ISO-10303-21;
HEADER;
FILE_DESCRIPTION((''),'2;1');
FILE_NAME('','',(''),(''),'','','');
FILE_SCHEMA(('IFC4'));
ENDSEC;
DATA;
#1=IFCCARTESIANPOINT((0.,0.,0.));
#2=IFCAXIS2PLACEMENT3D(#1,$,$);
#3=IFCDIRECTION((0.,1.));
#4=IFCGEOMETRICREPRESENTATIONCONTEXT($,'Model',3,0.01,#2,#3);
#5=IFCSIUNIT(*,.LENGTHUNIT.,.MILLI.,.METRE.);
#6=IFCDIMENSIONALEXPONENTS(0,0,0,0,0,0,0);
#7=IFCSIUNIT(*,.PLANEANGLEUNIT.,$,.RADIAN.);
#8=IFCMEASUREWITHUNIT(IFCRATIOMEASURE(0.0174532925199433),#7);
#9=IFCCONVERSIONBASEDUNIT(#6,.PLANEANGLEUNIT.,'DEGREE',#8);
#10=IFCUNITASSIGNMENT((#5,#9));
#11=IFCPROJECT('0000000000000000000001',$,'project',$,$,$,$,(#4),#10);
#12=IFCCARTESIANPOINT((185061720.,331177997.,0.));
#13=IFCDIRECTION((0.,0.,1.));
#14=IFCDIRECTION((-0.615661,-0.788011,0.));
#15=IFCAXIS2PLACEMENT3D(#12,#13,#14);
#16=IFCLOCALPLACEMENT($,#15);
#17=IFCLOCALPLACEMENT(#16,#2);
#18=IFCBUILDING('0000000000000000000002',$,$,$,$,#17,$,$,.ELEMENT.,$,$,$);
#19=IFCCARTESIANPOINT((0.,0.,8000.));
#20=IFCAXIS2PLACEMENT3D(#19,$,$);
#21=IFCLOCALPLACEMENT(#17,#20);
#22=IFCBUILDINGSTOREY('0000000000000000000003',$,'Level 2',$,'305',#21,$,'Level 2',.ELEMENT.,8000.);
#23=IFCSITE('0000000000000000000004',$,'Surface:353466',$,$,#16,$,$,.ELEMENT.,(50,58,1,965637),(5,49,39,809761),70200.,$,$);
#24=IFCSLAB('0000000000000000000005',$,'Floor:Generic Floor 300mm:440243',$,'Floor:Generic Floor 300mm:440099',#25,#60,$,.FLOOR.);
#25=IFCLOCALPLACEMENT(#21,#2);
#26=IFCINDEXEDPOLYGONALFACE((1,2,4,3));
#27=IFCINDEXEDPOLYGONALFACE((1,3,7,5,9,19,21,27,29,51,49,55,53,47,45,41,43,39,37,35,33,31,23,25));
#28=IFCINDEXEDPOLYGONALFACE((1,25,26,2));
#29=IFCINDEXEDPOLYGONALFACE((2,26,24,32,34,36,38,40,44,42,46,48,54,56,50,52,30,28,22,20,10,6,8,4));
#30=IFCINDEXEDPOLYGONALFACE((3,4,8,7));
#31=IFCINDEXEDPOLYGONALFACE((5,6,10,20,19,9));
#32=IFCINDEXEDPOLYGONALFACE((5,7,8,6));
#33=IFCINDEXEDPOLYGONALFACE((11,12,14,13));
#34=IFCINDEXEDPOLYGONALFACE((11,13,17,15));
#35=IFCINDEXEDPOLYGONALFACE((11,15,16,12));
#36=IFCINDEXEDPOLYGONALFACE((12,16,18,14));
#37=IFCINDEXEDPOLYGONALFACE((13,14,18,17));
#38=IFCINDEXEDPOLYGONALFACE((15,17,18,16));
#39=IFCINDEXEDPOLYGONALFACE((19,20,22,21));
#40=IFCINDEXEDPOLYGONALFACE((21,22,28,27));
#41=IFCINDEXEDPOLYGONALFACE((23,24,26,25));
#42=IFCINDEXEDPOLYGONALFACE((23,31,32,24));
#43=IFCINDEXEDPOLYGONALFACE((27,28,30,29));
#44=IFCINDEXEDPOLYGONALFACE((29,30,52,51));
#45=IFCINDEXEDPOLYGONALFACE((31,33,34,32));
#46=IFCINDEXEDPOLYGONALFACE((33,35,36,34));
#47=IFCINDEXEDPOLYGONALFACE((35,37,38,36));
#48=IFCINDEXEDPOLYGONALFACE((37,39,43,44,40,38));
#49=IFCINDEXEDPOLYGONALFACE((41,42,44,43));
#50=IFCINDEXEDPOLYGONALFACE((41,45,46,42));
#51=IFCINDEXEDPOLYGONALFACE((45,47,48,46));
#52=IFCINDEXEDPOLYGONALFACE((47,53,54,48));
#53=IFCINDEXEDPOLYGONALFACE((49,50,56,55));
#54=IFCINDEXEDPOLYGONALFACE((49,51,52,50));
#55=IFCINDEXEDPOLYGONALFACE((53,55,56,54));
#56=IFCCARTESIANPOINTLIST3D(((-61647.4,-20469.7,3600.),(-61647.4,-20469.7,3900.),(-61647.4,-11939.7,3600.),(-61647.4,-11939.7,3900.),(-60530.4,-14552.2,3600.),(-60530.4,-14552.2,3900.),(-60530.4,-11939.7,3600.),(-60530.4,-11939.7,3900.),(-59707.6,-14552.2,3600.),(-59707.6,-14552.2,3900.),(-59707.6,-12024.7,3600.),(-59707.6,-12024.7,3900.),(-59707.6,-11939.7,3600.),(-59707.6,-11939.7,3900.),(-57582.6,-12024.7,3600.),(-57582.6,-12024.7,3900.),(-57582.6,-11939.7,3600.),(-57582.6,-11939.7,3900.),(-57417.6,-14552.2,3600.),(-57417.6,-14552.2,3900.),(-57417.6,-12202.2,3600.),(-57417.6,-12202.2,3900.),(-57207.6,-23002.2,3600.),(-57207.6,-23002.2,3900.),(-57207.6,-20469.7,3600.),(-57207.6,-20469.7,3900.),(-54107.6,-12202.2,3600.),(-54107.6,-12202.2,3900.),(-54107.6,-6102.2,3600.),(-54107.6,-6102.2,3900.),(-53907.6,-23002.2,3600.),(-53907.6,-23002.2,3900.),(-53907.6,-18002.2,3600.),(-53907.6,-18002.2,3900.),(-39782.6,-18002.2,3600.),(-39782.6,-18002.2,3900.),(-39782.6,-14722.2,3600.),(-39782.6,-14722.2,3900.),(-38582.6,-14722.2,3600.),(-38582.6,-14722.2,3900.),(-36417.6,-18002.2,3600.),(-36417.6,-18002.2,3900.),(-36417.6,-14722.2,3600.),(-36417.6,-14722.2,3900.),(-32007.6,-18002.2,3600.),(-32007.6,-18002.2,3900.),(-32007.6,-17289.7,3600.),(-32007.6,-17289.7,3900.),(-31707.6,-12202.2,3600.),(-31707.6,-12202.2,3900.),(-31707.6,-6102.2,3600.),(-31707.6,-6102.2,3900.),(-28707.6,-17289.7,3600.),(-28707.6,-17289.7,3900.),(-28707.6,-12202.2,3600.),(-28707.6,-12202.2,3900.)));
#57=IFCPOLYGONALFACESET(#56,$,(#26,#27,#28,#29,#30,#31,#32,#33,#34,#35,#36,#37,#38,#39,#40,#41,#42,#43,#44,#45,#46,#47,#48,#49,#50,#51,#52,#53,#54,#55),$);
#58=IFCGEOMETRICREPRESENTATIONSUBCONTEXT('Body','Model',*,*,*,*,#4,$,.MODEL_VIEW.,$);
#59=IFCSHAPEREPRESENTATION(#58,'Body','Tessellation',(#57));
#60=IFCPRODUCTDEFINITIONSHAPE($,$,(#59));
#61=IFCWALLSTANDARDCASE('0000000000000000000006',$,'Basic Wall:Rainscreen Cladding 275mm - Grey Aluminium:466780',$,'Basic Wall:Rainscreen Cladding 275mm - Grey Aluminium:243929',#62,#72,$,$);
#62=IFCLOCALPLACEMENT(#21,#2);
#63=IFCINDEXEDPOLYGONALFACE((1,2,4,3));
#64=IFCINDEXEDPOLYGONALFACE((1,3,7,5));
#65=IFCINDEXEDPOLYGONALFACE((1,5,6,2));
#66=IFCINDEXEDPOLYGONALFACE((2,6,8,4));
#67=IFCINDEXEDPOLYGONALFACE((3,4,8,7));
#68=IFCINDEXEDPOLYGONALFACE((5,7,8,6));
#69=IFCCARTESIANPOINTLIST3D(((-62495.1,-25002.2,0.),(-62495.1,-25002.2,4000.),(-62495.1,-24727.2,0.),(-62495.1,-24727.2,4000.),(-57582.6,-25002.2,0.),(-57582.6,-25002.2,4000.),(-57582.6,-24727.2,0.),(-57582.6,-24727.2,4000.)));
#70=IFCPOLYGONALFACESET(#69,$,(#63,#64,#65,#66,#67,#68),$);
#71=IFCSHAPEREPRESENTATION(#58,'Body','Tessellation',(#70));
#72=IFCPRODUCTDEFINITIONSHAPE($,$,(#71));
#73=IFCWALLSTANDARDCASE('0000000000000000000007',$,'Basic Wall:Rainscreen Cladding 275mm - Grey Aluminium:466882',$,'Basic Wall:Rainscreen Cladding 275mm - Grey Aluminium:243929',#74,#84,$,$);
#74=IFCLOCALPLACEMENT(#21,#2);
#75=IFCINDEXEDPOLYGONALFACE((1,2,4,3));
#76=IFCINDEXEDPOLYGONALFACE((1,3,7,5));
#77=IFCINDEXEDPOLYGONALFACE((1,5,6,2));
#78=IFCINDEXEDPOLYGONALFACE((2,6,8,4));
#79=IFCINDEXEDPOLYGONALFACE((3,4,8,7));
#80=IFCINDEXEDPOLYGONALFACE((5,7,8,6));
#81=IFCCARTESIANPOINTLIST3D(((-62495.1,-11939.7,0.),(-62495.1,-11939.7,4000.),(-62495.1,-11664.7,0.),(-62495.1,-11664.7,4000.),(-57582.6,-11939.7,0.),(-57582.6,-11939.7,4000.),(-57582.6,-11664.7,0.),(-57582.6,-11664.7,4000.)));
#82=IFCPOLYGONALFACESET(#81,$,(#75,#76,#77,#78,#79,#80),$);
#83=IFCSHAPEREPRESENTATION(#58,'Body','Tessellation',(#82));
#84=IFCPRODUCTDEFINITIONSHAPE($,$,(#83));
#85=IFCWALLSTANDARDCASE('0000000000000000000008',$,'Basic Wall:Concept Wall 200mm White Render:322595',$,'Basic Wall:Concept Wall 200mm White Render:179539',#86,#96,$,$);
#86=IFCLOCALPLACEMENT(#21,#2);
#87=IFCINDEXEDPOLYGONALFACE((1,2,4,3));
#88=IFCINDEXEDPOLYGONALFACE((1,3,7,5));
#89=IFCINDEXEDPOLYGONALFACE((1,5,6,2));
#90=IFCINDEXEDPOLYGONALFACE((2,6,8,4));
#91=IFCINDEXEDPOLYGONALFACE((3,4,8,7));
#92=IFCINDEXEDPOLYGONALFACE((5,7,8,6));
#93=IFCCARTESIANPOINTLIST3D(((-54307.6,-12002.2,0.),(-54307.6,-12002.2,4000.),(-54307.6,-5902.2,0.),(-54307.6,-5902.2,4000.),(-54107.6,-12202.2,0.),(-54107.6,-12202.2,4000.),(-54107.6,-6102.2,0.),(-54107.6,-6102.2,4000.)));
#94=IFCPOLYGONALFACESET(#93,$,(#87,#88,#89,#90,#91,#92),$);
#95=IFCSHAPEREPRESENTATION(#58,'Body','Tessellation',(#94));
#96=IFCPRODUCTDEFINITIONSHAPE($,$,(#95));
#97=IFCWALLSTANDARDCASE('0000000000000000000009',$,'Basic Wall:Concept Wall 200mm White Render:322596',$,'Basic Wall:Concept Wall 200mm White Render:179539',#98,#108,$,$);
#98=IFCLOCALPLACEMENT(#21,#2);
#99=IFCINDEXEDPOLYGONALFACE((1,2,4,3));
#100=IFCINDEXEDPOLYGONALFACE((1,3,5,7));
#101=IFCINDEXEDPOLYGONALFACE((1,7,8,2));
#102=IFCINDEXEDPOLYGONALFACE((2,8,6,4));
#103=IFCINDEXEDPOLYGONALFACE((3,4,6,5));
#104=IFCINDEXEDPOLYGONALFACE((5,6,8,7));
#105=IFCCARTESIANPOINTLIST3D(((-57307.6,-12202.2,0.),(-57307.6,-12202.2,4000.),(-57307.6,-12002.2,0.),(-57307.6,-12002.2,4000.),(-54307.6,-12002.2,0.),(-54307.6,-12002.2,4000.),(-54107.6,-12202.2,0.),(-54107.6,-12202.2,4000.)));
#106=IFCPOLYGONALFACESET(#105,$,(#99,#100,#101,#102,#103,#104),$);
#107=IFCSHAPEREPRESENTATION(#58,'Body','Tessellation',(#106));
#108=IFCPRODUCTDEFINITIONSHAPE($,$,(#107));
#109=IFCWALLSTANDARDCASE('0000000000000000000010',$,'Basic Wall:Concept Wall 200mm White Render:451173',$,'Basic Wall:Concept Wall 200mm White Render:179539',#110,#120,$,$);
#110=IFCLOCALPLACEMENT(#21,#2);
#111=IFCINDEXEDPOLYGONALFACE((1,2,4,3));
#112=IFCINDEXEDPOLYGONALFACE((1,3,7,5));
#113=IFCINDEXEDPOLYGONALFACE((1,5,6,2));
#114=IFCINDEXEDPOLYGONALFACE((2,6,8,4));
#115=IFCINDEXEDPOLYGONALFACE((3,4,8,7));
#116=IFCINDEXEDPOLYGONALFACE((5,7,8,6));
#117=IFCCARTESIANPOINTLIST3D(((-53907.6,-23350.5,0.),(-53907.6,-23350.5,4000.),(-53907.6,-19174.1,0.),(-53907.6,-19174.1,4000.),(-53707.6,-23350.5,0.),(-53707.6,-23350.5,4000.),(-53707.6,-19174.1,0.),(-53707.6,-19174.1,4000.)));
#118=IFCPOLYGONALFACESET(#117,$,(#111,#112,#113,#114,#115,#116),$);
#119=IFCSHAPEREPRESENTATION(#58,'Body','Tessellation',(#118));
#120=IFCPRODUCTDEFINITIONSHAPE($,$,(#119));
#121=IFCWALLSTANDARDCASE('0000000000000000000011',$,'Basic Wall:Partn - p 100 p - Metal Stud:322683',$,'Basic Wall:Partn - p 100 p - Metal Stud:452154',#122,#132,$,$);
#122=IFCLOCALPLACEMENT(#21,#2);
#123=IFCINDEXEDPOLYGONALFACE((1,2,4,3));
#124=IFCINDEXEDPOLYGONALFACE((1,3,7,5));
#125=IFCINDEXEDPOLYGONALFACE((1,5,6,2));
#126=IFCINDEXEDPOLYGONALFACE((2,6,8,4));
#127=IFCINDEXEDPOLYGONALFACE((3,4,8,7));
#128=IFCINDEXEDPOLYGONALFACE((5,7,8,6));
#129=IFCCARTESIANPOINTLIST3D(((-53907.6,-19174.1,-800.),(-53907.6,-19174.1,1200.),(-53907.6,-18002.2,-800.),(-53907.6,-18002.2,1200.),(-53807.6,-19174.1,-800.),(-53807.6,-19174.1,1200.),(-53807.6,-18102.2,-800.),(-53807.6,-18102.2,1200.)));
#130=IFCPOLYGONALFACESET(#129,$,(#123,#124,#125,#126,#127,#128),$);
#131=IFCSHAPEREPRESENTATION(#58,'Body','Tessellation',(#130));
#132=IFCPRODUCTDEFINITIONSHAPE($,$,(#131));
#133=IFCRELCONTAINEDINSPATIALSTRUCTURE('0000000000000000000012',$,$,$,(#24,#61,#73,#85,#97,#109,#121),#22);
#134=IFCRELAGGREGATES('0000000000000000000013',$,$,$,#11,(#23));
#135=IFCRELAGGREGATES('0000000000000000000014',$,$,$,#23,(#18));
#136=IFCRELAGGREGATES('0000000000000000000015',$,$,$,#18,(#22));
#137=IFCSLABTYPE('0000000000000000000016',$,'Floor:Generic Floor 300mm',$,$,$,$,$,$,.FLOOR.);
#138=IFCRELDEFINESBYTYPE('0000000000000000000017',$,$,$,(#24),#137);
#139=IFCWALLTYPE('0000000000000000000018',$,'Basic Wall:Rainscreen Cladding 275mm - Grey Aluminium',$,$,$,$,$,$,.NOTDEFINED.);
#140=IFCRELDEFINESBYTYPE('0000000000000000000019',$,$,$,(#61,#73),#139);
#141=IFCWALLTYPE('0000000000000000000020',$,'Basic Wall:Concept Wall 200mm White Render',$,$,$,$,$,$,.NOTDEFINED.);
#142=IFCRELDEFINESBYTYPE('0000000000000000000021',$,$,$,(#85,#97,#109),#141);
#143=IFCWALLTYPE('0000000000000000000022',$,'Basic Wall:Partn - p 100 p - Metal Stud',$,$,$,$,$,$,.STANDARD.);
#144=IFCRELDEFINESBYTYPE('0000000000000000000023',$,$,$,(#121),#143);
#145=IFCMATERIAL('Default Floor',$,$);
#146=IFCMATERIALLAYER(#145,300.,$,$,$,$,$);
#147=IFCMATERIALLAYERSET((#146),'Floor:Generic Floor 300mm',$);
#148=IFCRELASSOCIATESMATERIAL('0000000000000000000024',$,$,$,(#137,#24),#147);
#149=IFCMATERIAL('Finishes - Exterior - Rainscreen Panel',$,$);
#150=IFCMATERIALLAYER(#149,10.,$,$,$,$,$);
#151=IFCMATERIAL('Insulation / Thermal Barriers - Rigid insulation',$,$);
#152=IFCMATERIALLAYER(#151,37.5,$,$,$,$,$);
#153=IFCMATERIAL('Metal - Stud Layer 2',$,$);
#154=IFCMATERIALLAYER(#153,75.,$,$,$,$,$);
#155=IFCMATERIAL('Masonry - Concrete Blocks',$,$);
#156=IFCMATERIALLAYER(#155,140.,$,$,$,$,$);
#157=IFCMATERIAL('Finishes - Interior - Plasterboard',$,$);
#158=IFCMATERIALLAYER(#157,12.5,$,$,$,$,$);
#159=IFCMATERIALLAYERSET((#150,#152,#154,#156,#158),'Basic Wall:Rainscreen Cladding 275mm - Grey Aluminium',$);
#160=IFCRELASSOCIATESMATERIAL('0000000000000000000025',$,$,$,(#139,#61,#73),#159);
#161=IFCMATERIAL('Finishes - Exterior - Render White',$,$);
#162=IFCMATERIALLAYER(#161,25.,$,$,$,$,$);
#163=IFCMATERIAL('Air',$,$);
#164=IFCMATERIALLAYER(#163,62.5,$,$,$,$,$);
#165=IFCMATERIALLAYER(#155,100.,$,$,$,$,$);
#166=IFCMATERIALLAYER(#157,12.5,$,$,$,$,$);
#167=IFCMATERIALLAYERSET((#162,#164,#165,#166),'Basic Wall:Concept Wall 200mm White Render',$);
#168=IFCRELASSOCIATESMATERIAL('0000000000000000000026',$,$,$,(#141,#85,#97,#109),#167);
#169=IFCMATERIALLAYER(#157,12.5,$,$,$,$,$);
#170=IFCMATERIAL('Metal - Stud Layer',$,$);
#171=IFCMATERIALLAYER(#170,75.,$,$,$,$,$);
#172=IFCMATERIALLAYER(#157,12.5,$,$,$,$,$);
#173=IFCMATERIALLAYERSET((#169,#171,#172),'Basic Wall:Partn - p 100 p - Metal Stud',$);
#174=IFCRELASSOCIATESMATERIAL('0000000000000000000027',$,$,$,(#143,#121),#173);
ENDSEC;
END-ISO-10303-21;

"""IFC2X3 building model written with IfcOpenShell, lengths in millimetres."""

from ifc_helpers import new_model, entity, si_unit, converted_unit, direction, frame, frame_2d, origin, place, context, subcontext, project, spatial, polyline, rectangle, outline, extrude, clip, halfspace, material, layer, layer_set, layer_usage, type_object, element, save


model = new_model("IFC2X3")

# Units and contexts
model_context = context("Model", 3, precision=0.01, world=origin(), true_north=direction((0.0, 1.0)))
body_context = subcontext(model_context, "Body", "Model", "MODEL_VIEW")
ifc_project = project(units=[si_unit("LENGTHUNIT", "METRE", prefix="MILLI"), converted_unit("PLANEANGLEUNIT", "DEGREE", entity("IfcRatioMeasure", 0.0174532925199433), si_unit("PLANEANGLEUNIT", "RADIAN"), dimensions=[0, 0, 0, 0, 0, 0, 0])], contexts=[model_context])

# Site, building, storey
site_placement = place(None, frame((185061720.0, 331177997.0, 0.0), z_axis=(0.0, 0.0, 1.0), x_axis=(-0.615661, -0.788011, 0.0)))
site = spatial("IfcSite", under=ifc_project, at=site_placement, Name="Surface:353466", CompositionType="ELEMENT", RefLatitude=(50, 58, 1, 965637), RefLongitude=(5, 49, 39, 809761), RefElevation=70200.0)
building_placement = place(site_placement, origin())
building = spatial("IfcBuilding", under=site, at=building_placement, CompositionType="ELEMENT")
storey_placement = place(building_placement, frame((0.0, 0.0, 8000.0)))
storey = spatial("IfcBuildingStorey", under=building, at=storey_placement, Name="Level 2", ObjectType="305", LongName="Level 2", CompositionType="ELEMENT", Elevation=8000.0)

# Slab, openings
ifc_material_1 = material(Name="Default Floor")
ifc_layer_1 = layer(ifc_material_1, 300.0)
ifc_layer_set_1 = layer_set([ifc_layer_1], Name="Floor:Generic Floor 300mm")
ifc_layer_usage_1 = layer_usage(ifc_layer_set_1, "AXIS3", "POSITIVE", 0.0)
slab_type = type_object("IfcSlabType", Name="Floor:Generic Floor 300mm", PredefinedType="FLOOR", material=ifc_layer_set_1)
slab_placement = place(storey_placement, frame((-61647.4, -23002.2, 3600.0)))
slab = element("IfcSlab", 1, at=slab_placement, inside=storey, type_object=slab_type, material=ifc_layer_usage_1, Name="Floor:Generic Floor 300mm:440243", ObjectType="Floor:Generic Floor 300mm:440099", PredefinedType="FLOOR", context=body_context, shape_type="SweptSolid", body=[
    extrude(outline(polyline([(-13469.9, 2350.0), (-16469.9, 2350.0), (-16469.9, -2737.5), (-13169.9, -2737.5), (-13169.9, -3450.0), (8730.1, -3450.0), (8730.1, -8450.0), (12030.1, -8450.0), (12030.1, -5917.5), (16469.9, -5917.5), (16469.9, 2612.5), (12405.1, 2612.5), (12405.1, 2350.0), (8930.1, 2350.0), (8930.1, 8450.0), (-13469.9, 8450.0), (-13469.9, 2350.0)])), frame((16469.9, 8450.0, 300.0), z_axis=(0.0, 0.0, -1.0), x_axis=(-1.0, 0.0, 0.0)), (0.0, 0.0, 1.0), 300.0),
])
opening_1_placement = place(storey_placement, frame((-61647.4, -23002.2, 3600.0)))
element("IfcOpeningElement", 2, at=opening_1_placement, cuts=slab, ObjectType="Opening", context=body_context, shape_type="SweptSolid", body=[
    extrude(rectangle(XDim=1550.0, YDim=1250.0, at=frame_2d((13355.1, 1175.0), x_axis=(1.0, 0.0))), frame((16469.9, 8450.0, 300.0), z_axis=(0.0, 0.0, -1.0), x_axis=(-1.0, 0.0, 0.0)), (0.0, 0.0, 1.0), 300.0),
])
opening_2_placement = place(storey_placement, frame((-61647.4, -23002.2, 3600.0)))
element("IfcOpeningElement", 3, at=opening_2_placement, cuts=slab, ObjectType="Opening", context=body_context, shape_type="SweptSolid", body=[
    extrude(rectangle(XDim=1550.0, YDim=1250.0, at=frame_2d((-7644.9, -1060.0), x_axis=(1.0, 0.0))), frame((16469.9, 8450.0, 300.0), z_axis=(0.0, 0.0, -1.0), x_axis=(-1.0, 0.0, 0.0)), (0.0, 0.0, 1.0), 300.0),
])
opening_3_placement = place(storey_placement, frame((-61647.4, -23002.2, 3600.0)))
element("IfcOpeningElement", 4, at=opening_3_placement, cuts=slab, ObjectType="Opening", context=body_context, shape_type="SweptSolid", body=[
    extrude(rectangle(XDim=1550.0, YDim=1250.0, at=frame_2d((-7644.9, -2660.0), x_axis=(1.0, 0.0))), frame((16469.9, 8450.0, 300.0), z_axis=(0.0, 0.0, -1.0), x_axis=(-1.0, 0.0, 0.0)), (0.0, 0.0, 1.0), 300.0),
])
opening_4_placement = place(storey_placement, frame((-61647.4, -23002.2, 3600.0)))
element("IfcOpeningElement", 5, at=opening_4_placement, cuts=slab, ObjectType="Opening", context=body_context, shape_type="SweptSolid", body=[
    extrude(rectangle(XDim=2527.5, YDim=2290.0, at=frame_2d((13385.1, 1263.8), x_axis=(0.0, -1.0))), frame((16469.9, 8450.0, 300.0), z_axis=(0.0, 0.0, -1.0), x_axis=(-1.0, 0.0, 0.0)), (0.0, 0.0, 1.0), 300.0),
])
opening_5_placement = place(storey_placement, frame((-61647.4, -23002.2, 3600.0)))
element("IfcOpeningElement", 6, at=opening_5_placement, cuts=slab, ObjectType="Opening", context=body_context, shape_type="SweptSolid", body=[
    extrude(rectangle(XDim=3380.0, YDim=2165.0, at=frame_2d((-7677.4, -1860.0), x_axis=(0.0, -1.0))), frame((16469.9, 8450.0, 300.0), z_axis=(0.0, 0.0, -1.0), x_axis=(-1.0, 0.0, 0.0)), (0.0, 0.0, 1.0), 300.0),
])
opening_6_placement = place(storey_placement, frame((-61647.4, -23002.2, 3600.0)))
element("IfcOpeningElement", 7, at=opening_6_placement, cuts=slab, ObjectType="Opening", context=body_context, shape_type="SweptSolid", body=[
    extrude(rectangle(XDim=3380.0, YDim=1200.0, at=frame_2d((-5994.9, -1860.0), x_axis=(0.0, 1.0))), frame((16469.9, 8450.0, 300.0), z_axis=(0.0, 0.0, -1.0), x_axis=(-1.0, 0.0, 0.0)), (0.0, 0.0, 1.0), 300.0),
])
opening_7_placement = place(storey_placement, frame((-61647.4, -23002.2, 3600.0)))
element("IfcOpeningElement", 8, at=opening_7_placement, cuts=slab, ObjectType="Opening", context=body_context, shape_type="SweptSolid", body=[
    extrude(rectangle(XDim=2612.5, YDim=822.9, at=frame_2d((14941.5, 1306.3), x_axis=(0.0, -1.0))), frame((16469.9, 8450.0, 300.0), z_axis=(0.0, 0.0, -1.0), x_axis=(-1.0, 0.0, 0.0)), (0.0, 0.0, 1.0), 300.0),
])

# Shared definitions
ifc_material_2 = material(Name="Finishes - Exterior - Rainscreen Panel")
ifc_layer_2 = layer(ifc_material_2, 10.0)
ifc_material_3 = material(Name="Insulation / Thermal Barriers - Rigid insulation")
ifc_layer_3 = layer(ifc_material_3, 37.5)
ifc_material_4 = material(Name="Metal - Stud Layer 2")
ifc_layer_4 = layer(ifc_material_4, 75.0)
ifc_material_5 = material(Name="Masonry - Concrete Blocks")
ifc_layer_5 = layer(ifc_material_5, 140.0)
ifc_material_6 = material(Name="Finishes - Interior - Plasterboard")
ifc_layer_6 = layer(ifc_material_6, 12.5)
ifc_layer_set_2 = layer_set([ifc_layer_2, ifc_layer_3, ifc_layer_4, ifc_layer_5, ifc_layer_6], Name="Basic Wall:Rainscreen Cladding 275mm - Grey Aluminium")
wall_type_1 = type_object("IfcWallType", Name="Basic Wall:Rainscreen Cladding 275mm - Grey Aluminium", PredefinedType="NOTDEFINED", material=ifc_layer_set_2)

# Walls
ifc_layer_usage_2 = layer_usage(ifc_layer_set_2, "AXIS2", "POSITIVE", -137.5)
wall_1_placement = place(storey_placement, frame((-62495.1, -24864.7, 0.0)))
element("IfcWallStandardCase", 9, at=wall_1_placement, inside=storey, type_object=wall_type_1, material=ifc_layer_usage_2, Name="Basic Wall:Rainscreen Cladding 275mm - Grey Aluminium:466780", ObjectType="Basic Wall:Rainscreen Cladding 275mm - Grey Aluminium:243929", context=body_context, shape_type="Clipping", body=[
    clip(extrude(rectangle(XDim=4912.5, YDim=275.0, at=frame_2d((2456.3, 0.0), x_axis=(-1.0, 0.0))), origin(), (0.0, 0.0, 1.0), 4000.0), halfspace(frame((0.0, 0.0, -8000.0)), True)),
])
ifc_layer_usage_3 = layer_usage(ifc_layer_set_2, "AXIS2", "POSITIVE", -137.5)
wall_2_placement = place(storey_placement, frame((-57582.6, -11802.2, 0.0), z_axis=(0.0, 0.0, 1.0), x_axis=(-1.0, 0.0, 0.0)))
element("IfcWallStandardCase", 10, at=wall_2_placement, inside=storey, type_object=wall_type_1, material=ifc_layer_usage_3, Name="Basic Wall:Rainscreen Cladding 275mm - Grey Aluminium:466882", ObjectType="Basic Wall:Rainscreen Cladding 275mm - Grey Aluminium:243929", context=body_context, shape_type="Clipping", body=[
    clip(extrude(rectangle(XDim=4912.5, YDim=275.0, at=frame_2d((2456.3, 0.0), x_axis=(-1.0, 0.0))), origin(), (0.0, 0.0, 1.0), 4000.0), halfspace(frame((0.0, 0.0, -8000.0)), True)),
])
ifc_material_7 = material(Name="Finishes - Exterior - Render White")
ifc_layer_7 = layer(ifc_material_7, 25.0)
ifc_material_8 = material(Name="Air")
ifc_layer_8 = layer(ifc_material_8, 62.5)
ifc_layer_9 = layer(ifc_material_5, 100.0)
ifc_layer_10 = layer(ifc_material_6, 12.5)
ifc_layer_set_3 = layer_set([ifc_layer_7, ifc_layer_8, ifc_layer_9, ifc_layer_10], Name="Basic Wall:Concept Wall 200mm White Render")
ifc_layer_usage_4 = layer_usage(ifc_layer_set_3, "AXIS2", "POSITIVE", -100.0)
wall_type_2 = type_object("IfcWallType", Name="Basic Wall:Concept Wall 200mm White Render", PredefinedType="NOTDEFINED", material=ifc_layer_set_3)
wall_3_placement = place(storey_placement, frame((-54207.6, -5902.2, 0.0), z_axis=(0.0, 0.0, 1.0), x_axis=(0.0, -1.0, 0.0)))
element("IfcWallStandardCase", 11, at=wall_3_placement, inside=storey, type_object=wall_type_2, material=ifc_layer_usage_4, Name="Basic Wall:Concept Wall 200mm White Render:322595", ObjectType="Basic Wall:Concept Wall 200mm White Render:179539", context=body_context, shape_type="Clipping", body=[
    clip(extrude(outline(polyline([(6100.0, -100.0), (6300.0, 100.0), (6135.0, 100.0), (200.0, 100.0), (0.0, -100.0), (6100.0, -100.0)])), origin(), (0.0, 0.0, 1.0), 4000.0), halfspace(frame((0.0, 0.0, -8000.0)), True)),
])
ifc_layer_usage_5 = layer_usage(ifc_layer_set_3, "AXIS2", "POSITIVE", -100.0)
wall_4_placement = place(storey_placement, frame((-54107.6, -12102.2, 0.0), z_axis=(0.0, 0.0, 1.0), x_axis=(-1.0, 0.0, 0.0)))
element("IfcWallStandardCase", 12, at=wall_4_placement, inside=storey, type_object=wall_type_2, material=ifc_layer_usage_5, Name="Basic Wall:Concept Wall 200mm White Render:322596", ObjectType="Basic Wall:Concept Wall 200mm White Render:179539", context=body_context, shape_type="Clipping", body=[
    clip(extrude(outline(polyline([(200.0, -100.0), (3200.0, -100.0), (3200.0, 100.0), (0.0, 100.0), (200.0, -100.0)])), origin(), (0.0, 0.0, 1.0), 4000.0), halfspace(frame((0.0, 0.0, -8000.0)), True)),
])
ifc_layer_usage_6 = layer_usage(ifc_layer_set_3, "AXIS2", "NEGATIVE", 100.0)
wall_5_placement = place(storey_placement, frame((-53807.6, -19174.1, 0.0), z_axis=(0.0, 0.0, 1.0), x_axis=(0.0, -1.0, 0.0)))
element("IfcWallStandardCase", 13, at=wall_5_placement, inside=storey, type_object=wall_type_2, material=ifc_layer_usage_6, Name="Basic Wall:Concept Wall 200mm White Render:451173", ObjectType="Basic Wall:Concept Wall 200mm White Render:179539", context=body_context, shape_type="Clipping", body=[
    clip(extrude(rectangle(XDim=4176.4, YDim=200.0, at=frame_2d((2088.2, 0.0), x_axis=(-1.0, 0.0))), origin(), (0.0, 0.0, 1.0), 4000.0), halfspace(frame((0.0, 0.0, -4000.0)), True)),
])
ifc_layer_11 = layer(ifc_material_6, 12.5)
ifc_material_9 = material(Name="Metal - Stud Layer")
ifc_layer_12 = layer(ifc_material_9, 75.0)
ifc_layer_13 = layer(ifc_material_6, 12.5)
ifc_layer_set_4 = layer_set([ifc_layer_11, ifc_layer_12, ifc_layer_13], Name="Basic Wall:Partn - p 100 p - Metal Stud")
ifc_layer_usage_7 = layer_usage(ifc_layer_set_4, "AXIS2", "NEGATIVE", 50.0)
wall_type_3 = type_object("IfcWallType", Name="Basic Wall:Partn - p 100 p - Metal Stud", PredefinedType="STANDARD", material=ifc_layer_set_4)
wall_6_placement = place(storey_placement, frame((-53857.6, -18002.2, -800.0), z_axis=(0.0, 0.0, 1.0), x_axis=(0.0, -1.0, 0.0)))
element("IfcWallStandardCase", 14, at=wall_6_placement, inside=storey, type_object=wall_type_3, material=ifc_layer_usage_7, Name="Basic Wall:Partn - p 100 p - Metal Stud:322683", ObjectType="Basic Wall:Partn - p 100 p - Metal Stud:452154", context=body_context, shape_type="SweptSolid", body=[
    extrude(outline(polyline([(1171.9, -50.0), (1171.9, 50.0), (100.0, 50.0), (0.0, -50.0), (1171.9, -50.0)])), origin(), (0.0, 0.0, 1.0), 2000.0),
])

save(model, "model.ifc")
